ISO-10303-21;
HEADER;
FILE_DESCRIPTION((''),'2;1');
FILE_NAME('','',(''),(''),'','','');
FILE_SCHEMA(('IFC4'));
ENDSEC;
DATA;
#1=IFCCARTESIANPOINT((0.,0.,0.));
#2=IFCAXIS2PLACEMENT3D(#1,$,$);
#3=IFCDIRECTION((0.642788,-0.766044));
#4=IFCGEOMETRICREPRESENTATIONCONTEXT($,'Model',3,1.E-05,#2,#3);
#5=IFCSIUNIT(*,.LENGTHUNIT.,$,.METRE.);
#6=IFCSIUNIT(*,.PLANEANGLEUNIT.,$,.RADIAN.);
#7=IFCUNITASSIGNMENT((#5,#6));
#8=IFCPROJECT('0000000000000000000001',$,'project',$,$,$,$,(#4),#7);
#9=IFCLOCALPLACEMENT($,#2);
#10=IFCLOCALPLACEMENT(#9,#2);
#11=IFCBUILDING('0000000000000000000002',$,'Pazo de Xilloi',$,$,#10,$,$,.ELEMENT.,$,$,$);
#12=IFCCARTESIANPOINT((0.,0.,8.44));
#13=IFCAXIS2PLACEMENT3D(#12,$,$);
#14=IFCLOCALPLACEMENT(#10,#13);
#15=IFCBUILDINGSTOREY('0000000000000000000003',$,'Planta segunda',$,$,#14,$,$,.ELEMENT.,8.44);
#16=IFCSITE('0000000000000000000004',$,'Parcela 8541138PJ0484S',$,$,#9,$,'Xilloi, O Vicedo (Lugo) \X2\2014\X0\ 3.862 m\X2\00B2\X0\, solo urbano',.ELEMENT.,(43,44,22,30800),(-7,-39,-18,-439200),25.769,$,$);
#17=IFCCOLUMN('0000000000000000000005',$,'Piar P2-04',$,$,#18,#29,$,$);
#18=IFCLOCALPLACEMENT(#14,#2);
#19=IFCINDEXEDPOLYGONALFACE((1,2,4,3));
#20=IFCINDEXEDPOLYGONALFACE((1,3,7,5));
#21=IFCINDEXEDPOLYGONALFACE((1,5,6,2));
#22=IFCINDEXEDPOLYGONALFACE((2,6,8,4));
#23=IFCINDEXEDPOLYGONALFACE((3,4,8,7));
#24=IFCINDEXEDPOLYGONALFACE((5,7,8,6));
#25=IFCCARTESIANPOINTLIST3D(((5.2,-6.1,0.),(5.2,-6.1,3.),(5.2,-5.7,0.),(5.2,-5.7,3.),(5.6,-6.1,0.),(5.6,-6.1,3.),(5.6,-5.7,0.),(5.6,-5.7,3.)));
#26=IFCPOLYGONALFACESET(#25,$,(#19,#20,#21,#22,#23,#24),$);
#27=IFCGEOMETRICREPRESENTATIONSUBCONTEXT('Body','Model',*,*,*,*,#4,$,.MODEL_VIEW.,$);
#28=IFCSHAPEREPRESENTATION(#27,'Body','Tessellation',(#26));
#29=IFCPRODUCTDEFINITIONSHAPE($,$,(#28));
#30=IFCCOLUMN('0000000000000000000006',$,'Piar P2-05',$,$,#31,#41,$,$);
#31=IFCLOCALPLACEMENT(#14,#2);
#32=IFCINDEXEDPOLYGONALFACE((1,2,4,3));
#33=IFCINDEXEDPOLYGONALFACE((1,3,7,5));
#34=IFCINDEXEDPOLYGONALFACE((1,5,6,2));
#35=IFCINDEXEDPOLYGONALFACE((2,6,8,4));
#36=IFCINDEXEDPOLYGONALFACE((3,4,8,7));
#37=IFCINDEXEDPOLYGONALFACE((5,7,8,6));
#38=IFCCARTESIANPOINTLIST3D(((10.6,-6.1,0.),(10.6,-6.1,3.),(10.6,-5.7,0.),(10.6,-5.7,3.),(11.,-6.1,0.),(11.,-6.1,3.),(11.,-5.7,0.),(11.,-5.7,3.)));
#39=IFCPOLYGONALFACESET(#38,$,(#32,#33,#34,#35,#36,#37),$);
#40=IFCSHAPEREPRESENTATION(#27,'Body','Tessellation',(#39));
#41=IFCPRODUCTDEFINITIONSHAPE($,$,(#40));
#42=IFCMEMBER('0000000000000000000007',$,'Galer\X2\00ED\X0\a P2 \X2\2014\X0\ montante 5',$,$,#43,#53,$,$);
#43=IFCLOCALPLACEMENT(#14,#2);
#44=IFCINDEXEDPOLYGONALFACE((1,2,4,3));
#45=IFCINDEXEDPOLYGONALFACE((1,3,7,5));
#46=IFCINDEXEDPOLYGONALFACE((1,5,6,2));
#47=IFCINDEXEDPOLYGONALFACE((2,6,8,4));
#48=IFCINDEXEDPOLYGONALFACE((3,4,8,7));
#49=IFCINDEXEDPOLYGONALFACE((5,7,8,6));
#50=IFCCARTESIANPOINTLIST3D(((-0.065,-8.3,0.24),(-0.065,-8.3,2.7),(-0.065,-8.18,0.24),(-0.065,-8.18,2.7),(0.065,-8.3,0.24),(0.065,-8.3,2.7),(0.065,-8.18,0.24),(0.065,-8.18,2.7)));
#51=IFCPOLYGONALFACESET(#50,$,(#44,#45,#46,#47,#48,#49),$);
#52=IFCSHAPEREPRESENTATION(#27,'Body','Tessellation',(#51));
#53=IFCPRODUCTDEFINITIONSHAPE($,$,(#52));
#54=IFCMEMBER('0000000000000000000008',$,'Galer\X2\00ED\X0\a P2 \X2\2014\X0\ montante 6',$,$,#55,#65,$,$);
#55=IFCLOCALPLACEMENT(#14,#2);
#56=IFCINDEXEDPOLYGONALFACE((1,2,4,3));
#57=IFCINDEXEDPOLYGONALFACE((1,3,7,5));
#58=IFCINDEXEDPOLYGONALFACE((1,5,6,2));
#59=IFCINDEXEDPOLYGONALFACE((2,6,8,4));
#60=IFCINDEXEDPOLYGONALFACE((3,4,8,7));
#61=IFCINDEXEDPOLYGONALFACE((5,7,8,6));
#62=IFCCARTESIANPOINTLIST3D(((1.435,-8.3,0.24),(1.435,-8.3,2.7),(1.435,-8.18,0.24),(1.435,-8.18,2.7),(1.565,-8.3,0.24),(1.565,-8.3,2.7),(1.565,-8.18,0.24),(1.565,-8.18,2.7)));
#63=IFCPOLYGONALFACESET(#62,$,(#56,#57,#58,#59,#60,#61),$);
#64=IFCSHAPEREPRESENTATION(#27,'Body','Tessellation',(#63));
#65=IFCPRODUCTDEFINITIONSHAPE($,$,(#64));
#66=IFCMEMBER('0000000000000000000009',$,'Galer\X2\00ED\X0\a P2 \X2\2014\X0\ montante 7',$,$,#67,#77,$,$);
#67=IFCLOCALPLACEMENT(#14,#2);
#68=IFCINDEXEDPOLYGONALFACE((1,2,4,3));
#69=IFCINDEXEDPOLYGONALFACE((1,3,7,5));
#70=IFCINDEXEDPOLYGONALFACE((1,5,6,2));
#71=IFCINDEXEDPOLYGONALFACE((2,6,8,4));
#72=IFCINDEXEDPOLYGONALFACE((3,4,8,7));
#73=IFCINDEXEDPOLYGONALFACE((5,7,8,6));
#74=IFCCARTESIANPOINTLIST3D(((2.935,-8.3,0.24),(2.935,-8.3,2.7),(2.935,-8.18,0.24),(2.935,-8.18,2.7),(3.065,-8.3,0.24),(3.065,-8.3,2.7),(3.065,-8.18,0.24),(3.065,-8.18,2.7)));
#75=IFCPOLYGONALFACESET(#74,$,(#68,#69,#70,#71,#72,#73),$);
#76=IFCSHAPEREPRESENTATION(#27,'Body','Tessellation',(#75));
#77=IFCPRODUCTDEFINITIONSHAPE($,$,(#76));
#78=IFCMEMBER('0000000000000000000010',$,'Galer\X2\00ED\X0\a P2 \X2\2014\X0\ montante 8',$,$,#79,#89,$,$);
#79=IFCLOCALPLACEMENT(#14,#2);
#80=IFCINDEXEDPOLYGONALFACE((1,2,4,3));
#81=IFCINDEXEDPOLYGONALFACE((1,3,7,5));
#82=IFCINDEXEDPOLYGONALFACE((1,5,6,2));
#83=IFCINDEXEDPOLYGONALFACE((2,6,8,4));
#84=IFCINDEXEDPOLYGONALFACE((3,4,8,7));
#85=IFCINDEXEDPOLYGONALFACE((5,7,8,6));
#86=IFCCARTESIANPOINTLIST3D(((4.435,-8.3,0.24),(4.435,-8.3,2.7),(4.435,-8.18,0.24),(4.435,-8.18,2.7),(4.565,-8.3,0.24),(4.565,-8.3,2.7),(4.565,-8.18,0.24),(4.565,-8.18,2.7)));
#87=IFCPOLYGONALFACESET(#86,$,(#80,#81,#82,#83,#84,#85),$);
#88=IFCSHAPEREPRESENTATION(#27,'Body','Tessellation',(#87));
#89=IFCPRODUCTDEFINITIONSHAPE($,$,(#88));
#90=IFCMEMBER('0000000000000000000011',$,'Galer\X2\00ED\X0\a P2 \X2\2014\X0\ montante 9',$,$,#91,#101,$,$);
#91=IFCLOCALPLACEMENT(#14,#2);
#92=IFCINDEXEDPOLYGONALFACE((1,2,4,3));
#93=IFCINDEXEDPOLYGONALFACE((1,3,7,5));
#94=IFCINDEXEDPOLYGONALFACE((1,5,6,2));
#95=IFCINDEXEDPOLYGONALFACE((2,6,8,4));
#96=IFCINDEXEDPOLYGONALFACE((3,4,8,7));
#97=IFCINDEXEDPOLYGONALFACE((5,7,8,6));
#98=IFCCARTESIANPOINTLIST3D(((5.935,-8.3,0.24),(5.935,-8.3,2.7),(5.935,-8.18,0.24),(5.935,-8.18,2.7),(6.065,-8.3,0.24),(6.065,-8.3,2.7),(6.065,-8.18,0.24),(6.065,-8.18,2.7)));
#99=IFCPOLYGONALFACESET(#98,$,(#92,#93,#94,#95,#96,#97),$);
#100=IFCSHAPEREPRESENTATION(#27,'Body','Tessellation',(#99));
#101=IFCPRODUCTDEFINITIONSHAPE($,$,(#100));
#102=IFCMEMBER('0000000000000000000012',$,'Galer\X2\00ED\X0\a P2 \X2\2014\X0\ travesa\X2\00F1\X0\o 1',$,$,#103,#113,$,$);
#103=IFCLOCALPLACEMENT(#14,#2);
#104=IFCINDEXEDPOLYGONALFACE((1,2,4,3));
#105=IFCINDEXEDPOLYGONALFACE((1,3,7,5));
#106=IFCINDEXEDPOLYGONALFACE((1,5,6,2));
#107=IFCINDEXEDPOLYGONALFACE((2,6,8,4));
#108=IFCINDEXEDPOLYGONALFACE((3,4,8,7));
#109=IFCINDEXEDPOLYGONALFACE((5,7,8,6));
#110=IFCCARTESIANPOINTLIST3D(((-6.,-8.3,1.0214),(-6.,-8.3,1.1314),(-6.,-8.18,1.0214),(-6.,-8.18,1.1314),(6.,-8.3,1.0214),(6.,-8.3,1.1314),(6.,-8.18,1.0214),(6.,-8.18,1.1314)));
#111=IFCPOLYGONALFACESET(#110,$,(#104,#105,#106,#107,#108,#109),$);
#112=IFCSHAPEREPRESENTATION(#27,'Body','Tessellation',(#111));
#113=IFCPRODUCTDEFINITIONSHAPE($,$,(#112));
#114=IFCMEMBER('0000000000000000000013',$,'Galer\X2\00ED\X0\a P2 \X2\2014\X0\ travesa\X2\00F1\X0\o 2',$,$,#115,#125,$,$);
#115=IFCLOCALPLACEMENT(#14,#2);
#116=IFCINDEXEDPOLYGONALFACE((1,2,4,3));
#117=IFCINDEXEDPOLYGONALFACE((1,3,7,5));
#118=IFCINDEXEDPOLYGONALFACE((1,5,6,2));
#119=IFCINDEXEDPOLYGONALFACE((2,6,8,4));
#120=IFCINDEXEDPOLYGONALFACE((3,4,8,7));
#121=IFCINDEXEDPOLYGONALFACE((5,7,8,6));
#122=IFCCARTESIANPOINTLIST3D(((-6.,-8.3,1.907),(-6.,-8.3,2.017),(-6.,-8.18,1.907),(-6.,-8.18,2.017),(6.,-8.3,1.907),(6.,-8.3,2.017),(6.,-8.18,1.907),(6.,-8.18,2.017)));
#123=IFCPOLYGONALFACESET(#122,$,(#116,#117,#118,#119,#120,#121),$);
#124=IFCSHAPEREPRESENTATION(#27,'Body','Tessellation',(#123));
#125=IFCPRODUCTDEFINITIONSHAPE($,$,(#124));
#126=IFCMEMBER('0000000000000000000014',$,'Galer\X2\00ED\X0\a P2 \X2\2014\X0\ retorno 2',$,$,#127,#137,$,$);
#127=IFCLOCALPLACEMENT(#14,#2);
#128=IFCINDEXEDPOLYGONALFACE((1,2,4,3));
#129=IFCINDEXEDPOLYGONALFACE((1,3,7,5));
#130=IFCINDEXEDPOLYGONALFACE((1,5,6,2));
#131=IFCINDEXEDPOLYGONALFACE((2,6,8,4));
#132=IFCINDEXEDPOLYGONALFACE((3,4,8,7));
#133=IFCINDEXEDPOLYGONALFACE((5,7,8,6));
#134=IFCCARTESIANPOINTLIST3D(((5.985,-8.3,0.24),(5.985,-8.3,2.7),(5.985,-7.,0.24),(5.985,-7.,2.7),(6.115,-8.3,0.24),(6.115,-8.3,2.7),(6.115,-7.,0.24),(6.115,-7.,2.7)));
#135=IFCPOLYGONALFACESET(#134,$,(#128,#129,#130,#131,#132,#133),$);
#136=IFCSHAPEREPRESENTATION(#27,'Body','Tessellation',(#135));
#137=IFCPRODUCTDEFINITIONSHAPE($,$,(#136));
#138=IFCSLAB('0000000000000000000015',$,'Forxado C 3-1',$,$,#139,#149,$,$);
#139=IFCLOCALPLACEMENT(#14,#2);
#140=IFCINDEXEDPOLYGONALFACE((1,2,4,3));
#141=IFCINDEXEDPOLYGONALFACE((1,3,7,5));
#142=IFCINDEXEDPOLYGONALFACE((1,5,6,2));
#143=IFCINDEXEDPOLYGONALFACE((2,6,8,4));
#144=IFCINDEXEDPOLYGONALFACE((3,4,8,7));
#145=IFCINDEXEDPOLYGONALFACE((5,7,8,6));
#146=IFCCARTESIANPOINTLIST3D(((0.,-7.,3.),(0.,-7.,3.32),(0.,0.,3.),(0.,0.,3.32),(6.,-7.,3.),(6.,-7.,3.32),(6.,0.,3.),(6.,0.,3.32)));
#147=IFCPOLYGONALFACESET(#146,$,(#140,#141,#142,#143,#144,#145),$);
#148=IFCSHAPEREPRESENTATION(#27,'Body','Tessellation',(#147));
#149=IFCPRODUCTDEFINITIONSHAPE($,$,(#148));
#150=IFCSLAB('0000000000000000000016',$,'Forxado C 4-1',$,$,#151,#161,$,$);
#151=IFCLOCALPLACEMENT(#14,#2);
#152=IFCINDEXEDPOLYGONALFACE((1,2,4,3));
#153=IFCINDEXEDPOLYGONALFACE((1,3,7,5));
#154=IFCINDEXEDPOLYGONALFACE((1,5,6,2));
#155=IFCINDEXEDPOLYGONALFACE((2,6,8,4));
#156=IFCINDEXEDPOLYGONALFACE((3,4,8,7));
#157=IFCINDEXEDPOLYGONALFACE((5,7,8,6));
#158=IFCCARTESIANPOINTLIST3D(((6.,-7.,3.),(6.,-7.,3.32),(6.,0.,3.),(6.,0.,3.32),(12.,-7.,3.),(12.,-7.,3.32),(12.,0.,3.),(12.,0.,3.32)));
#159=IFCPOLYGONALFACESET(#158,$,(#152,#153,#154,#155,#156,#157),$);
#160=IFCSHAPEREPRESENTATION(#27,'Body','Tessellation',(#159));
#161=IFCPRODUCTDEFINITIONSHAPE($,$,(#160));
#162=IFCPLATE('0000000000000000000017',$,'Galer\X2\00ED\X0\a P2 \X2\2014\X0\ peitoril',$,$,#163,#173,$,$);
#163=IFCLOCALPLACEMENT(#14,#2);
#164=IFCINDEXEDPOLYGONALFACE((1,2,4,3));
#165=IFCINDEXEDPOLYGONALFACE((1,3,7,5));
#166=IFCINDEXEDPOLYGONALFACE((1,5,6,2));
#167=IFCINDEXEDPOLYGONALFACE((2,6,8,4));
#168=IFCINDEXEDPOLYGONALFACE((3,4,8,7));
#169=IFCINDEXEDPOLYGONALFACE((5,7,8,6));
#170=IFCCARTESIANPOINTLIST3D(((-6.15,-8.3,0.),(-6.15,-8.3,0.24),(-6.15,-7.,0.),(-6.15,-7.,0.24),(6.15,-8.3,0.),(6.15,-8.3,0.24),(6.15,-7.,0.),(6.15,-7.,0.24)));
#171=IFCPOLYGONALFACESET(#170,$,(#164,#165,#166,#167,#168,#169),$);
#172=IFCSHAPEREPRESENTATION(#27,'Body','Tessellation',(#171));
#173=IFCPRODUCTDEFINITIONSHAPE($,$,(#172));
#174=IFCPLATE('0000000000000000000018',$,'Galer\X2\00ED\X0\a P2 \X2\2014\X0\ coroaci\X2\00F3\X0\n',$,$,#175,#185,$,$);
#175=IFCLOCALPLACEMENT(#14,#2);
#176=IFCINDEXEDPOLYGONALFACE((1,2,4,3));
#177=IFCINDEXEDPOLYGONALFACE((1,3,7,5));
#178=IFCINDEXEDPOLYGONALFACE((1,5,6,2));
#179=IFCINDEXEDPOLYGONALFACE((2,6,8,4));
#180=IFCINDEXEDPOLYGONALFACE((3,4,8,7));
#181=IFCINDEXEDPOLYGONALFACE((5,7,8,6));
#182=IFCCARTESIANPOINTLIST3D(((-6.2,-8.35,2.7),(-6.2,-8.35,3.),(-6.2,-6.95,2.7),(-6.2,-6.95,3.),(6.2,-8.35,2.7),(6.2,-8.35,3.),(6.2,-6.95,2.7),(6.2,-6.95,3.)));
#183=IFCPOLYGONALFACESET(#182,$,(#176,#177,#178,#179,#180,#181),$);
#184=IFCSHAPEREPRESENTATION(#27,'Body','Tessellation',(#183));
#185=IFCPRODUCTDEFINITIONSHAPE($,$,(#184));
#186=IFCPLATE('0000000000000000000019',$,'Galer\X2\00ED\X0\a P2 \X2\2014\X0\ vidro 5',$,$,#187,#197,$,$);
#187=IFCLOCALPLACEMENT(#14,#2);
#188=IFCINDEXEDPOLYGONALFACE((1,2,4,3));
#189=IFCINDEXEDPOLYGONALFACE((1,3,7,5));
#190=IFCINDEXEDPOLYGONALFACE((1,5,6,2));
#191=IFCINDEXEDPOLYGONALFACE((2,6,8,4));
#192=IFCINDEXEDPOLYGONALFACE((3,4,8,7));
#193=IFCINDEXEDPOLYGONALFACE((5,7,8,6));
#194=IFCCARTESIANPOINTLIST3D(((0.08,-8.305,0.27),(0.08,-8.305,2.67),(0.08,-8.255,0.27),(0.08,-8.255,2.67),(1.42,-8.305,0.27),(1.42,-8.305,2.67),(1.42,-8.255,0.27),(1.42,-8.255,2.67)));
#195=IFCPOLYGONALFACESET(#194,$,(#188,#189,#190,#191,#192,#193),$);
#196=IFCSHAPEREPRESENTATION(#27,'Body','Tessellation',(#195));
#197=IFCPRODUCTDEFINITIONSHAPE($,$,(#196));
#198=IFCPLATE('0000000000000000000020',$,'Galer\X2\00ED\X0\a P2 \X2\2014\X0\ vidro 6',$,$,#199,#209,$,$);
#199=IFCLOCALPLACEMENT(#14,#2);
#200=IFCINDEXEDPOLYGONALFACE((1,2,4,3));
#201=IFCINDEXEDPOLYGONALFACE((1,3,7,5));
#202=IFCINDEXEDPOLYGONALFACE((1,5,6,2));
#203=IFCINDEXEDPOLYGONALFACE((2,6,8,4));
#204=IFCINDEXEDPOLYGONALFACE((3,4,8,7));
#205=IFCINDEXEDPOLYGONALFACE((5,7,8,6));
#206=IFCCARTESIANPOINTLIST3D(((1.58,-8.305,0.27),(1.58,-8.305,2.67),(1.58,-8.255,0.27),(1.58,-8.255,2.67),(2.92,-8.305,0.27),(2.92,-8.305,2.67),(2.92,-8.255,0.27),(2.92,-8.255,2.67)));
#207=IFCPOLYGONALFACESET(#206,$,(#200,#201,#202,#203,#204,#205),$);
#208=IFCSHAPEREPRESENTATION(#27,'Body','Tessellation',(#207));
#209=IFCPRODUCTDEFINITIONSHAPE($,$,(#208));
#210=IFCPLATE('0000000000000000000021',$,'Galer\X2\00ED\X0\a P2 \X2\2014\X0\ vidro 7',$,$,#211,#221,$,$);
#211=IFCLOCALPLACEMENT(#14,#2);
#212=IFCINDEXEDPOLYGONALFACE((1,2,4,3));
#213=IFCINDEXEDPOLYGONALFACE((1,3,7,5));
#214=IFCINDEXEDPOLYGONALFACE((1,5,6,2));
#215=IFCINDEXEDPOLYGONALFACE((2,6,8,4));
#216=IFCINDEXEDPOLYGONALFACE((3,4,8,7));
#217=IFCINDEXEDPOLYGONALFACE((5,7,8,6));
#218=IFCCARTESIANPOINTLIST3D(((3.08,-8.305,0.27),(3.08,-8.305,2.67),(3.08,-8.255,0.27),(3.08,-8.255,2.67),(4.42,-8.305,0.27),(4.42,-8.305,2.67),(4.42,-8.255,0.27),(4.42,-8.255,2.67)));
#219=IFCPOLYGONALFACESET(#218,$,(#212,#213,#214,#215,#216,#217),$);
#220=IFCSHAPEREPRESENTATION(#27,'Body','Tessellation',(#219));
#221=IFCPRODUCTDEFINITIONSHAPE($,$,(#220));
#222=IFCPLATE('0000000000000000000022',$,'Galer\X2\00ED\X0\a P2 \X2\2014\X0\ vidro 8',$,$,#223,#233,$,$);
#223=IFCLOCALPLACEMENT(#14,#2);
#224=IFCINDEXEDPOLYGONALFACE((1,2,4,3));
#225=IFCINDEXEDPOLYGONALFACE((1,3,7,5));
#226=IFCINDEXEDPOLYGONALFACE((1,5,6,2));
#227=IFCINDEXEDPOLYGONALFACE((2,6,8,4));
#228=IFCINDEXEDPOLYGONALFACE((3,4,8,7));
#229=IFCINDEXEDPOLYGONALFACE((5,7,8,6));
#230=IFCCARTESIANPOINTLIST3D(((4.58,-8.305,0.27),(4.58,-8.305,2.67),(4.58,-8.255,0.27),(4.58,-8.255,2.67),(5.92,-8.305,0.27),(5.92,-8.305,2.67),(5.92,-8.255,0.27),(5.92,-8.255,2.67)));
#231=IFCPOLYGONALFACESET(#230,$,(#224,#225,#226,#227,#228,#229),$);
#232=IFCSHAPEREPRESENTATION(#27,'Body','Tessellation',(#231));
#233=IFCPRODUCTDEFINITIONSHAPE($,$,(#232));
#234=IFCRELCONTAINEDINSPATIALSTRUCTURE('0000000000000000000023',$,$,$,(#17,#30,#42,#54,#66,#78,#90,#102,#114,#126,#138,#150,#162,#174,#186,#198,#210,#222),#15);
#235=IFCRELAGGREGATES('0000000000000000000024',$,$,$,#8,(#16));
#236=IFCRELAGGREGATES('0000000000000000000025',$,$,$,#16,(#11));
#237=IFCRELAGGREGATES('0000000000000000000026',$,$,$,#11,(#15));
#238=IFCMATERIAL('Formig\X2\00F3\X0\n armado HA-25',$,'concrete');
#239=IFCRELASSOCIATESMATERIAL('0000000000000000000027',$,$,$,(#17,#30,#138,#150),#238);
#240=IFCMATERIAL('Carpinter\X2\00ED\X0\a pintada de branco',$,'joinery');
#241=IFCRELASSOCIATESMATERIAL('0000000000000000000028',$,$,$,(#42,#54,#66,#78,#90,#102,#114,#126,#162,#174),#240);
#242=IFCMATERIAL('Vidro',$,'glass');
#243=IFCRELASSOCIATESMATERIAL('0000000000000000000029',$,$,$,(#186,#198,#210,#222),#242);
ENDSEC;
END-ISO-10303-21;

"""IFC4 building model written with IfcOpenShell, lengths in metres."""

from ifc_helpers import new_model, si_unit, direction, frame, origin, origin_2d, place, context, subcontext, project, spatial, rectangle, extrude, material, element, save


model = new_model("IFC4")

# Units and contexts
model_context = context("Model", 3, precision=1e-05, world=origin(), true_north=direction((0.642788, -0.766044)))
body_context = subcontext(model_context, "Body", "Model", "MODEL_VIEW")
ifc_project = project(units=[si_unit("LENGTHUNIT", "METRE"), si_unit("PLANEANGLEUNIT", "RADIAN")], contexts=[model_context])

# Site, building, storey
site_placement = place(None, origin())
site = spatial("IfcSite", under=ifc_project, at=site_placement, Name="Parcela 8541138PJ0484S", LongName="Xilloi, O Vicedo (Lugo) — 3.862 m², solo urbano", CompositionType="ELEMENT", RefLatitude=(43, 44, 22, 30800), RefLongitude=(-7, -39, -18, -439200), RefElevation=25.769)
building_placement = place(site_placement, origin())
building = spatial("IfcBuilding", under=site, at=building_placement, Name="Pazo de Xilloi", CompositionType="ELEMENT")
storey_placement = place(building_placement, frame((0.0, 0.0, 8.44)))
storey = spatial("IfcBuildingStorey", under=building, at=storey_placement, Name="Planta segunda", CompositionType="ELEMENT", Elevation=8.44)

# Columns
ifc_material_1 = material(Name="Formigón armado HA-25", Category="concrete")
for number, where, name in (
    (1, (5.4, -5.9, 1.5), "Piar P2-04"),
    (2, (10.8, -5.9, 1.5), "Piar P2-05"),
):
    element("IfcColumn", number, at=place(storey_placement, frame(where)), inside=storey, material=ifc_material_1, Name=name, context=body_context, shape_type="SweptSolid", body=[
        extrude(rectangle(XDim=0.4, YDim=0.4, at=origin_2d()), frame((0.0, 0.0, -1.5)), (0.0, 0.0, 1.0), 3.0),
    ])

# Members
ifc_material_2 = material(Name="Carpintería pintada de branco", Category="joinery")
for number, where, name in (
    (3, (0.0, -8.24, 1.47), "Galería P2 — montante 5"),
    (4, (1.5, -8.24, 1.47), "Galería P2 — montante 6"),
    (5, (3.0, -8.24, 1.47), "Galería P2 — montante 7"),
    (6, (4.5, -8.24, 1.47), "Galería P2 — montante 8"),
    (7, (6.0, -8.24, 1.47), "Galería P2 — montante 9"),
):
    element("IfcMember", number, at=place(storey_placement, frame(where)), inside=storey, material=ifc_material_2, Name=name, context=body_context, shape_type="SweptSolid", body=[
        extrude(rectangle(XDim=0.13, YDim=0.12, at=origin_2d()), frame((0.0, 0.0, -1.23)), (0.0, 0.0, 1.0), 2.46),
    ])
for number, where, name in (
    (8, (0.0, -8.24, 1.0764), "Galería P2 — travesaño 1"),
    (9, (0.0, -8.24, 1.962), "Galería P2 — travesaño 2"),
):
    element("IfcMember", number, at=place(storey_placement, frame(where)), inside=storey, material=ifc_material_2, Name=name, context=body_context, shape_type="SweptSolid", body=[
        extrude(rectangle(XDim=12.0, YDim=0.12, at=origin_2d()), frame((0.0, 0.0, -0.055)), (0.0, 0.0, 1.0), 0.11),
    ])
member_placement = place(storey_placement, frame((6.05, -7.65, 1.47)))
element("IfcMember", 10, at=member_placement, inside=storey, material=ifc_material_2, Name="Galería P2 — retorno 2", context=body_context, shape_type="SweptSolid", body=[
    extrude(rectangle(XDim=0.13, YDim=1.3, at=origin_2d()), frame((0.0, 0.0, -1.23)), (0.0, 0.0, 1.0), 2.46),
])

# Slabs
for number, where, name in (
    (11, (3.0, -3.5, 3.16), "Forxado C 3-1"),
    (12, (9.0, -3.5, 3.16), "Forxado C 4-1"),
):
    element("IfcSlab", number, at=place(storey_placement, frame(where)), inside=storey, material=ifc_material_1, Name=name, context=body_context, shape_type="SweptSolid", body=[
        extrude(rectangle(XDim=6.0, YDim=7.0, at=origin_2d()), frame((0.0, 0.0, -0.16)), (0.0, 0.0, 1.0), 0.32),
    ])

# Plates
plate_1_placement = place(storey_placement, frame((0.0, -7.65, 0.12)))
element("IfcPlate", 13, at=plate_1_placement, inside=storey, material=ifc_material_2, Name="Galería P2 — peitoril", context=body_context, shape_type="SweptSolid", body=[
    extrude(rectangle(XDim=12.3, YDim=1.3, at=origin_2d()), frame((0.0, 0.0, -0.12)), (0.0, 0.0, 1.0), 0.24),
])
plate_2_placement = place(storey_placement, frame((0.0, -7.65, 2.85)))
element("IfcPlate", 14, at=plate_2_placement, inside=storey, material=ifc_material_2, Name="Galería P2 — coroación", context=body_context, shape_type="SweptSolid", body=[
    extrude(rectangle(XDim=12.4, YDim=1.4, at=origin_2d()), frame((0.0, 0.0, -0.15)), (0.0, 0.0, 1.0), 0.3),
])
ifc_material_3 = material(Name="Vidro", Category="glass")
for number, where, name in (
    (15, (0.75, -8.28, 1.47), "Galería P2 — vidro 5"),
    (16, (2.25, -8.28, 1.47), "Galería P2 — vidro 6"),
    (17, (3.75, -8.28, 1.47), "Galería P2 — vidro 7"),
    (18, (5.25, -8.28, 1.47), "Galería P2 — vidro 8"),
):
    element("IfcPlate", number, at=place(storey_placement, frame(where)), inside=storey, material=ifc_material_3, Name=name, context=body_context, shape_type="SweptSolid", body=[
        extrude(rectangle(XDim=1.34, YDim=0.05, at=origin_2d()), frame((0.0, 0.0, -1.2)), (0.0, 0.0, 1.0), 2.4),
    ])

save(model, "model.ifc")
